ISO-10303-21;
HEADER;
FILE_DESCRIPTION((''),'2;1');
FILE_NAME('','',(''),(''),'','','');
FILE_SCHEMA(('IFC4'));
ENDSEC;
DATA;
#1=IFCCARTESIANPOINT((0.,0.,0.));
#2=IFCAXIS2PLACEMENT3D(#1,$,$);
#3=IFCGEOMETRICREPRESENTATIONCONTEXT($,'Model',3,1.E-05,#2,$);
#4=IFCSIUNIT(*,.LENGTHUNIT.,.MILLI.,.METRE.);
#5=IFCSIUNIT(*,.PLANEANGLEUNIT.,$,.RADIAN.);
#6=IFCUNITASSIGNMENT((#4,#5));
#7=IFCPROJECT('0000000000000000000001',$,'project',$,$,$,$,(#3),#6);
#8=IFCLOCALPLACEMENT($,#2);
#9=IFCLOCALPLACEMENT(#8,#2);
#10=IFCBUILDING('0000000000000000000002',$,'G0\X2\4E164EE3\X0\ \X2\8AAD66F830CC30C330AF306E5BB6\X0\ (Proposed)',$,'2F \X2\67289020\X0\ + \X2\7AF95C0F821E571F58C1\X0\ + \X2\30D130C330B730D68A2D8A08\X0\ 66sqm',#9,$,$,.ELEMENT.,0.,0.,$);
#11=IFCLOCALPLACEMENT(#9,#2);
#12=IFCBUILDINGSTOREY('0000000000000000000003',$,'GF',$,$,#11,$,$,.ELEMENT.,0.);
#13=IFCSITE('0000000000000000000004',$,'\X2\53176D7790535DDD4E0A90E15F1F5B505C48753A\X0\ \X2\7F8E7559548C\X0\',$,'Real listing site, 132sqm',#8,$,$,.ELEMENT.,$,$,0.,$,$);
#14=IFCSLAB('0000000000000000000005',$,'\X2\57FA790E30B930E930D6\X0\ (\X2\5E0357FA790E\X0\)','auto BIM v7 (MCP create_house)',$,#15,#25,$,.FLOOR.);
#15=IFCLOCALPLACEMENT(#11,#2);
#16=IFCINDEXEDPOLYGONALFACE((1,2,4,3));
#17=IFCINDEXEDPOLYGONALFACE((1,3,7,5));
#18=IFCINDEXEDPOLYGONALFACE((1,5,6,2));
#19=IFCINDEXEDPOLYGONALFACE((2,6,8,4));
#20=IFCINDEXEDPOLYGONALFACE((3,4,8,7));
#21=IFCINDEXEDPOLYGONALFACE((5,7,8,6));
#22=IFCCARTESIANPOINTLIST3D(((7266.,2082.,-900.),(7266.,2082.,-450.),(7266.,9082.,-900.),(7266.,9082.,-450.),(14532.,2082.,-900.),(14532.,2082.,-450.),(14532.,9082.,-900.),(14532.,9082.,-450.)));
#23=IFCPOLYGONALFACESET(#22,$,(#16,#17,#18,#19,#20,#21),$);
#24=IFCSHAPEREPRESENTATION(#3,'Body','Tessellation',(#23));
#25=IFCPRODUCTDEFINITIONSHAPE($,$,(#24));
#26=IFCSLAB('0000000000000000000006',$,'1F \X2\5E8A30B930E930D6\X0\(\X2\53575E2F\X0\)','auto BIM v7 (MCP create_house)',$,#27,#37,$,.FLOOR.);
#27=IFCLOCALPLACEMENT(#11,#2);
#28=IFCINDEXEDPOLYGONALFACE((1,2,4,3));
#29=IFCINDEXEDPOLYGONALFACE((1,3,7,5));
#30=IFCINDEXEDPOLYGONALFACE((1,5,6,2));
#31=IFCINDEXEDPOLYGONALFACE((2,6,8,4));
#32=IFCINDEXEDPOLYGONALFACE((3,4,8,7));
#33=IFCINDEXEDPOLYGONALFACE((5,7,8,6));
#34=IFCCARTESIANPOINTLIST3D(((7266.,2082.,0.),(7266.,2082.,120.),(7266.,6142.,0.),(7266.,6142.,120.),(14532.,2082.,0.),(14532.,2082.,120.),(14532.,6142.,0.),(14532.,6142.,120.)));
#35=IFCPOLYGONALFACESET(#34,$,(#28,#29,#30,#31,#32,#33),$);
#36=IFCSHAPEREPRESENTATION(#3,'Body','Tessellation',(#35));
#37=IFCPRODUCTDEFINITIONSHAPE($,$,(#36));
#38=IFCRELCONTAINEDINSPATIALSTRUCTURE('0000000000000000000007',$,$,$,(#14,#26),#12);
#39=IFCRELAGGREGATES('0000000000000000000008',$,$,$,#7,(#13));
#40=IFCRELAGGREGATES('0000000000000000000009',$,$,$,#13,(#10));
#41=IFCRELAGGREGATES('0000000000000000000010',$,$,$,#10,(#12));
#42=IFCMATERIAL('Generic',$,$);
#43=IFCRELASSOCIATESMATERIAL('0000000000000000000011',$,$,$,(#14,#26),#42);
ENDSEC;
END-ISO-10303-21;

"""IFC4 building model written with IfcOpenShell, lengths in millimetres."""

from ifc_helpers import new_model, si_unit, frame, frame_2d, origin, place, context, project, spatial, rectangle, extrude, material, element, save


model = new_model("IFC4")

# Units and contexts
model_context = context("Model", 3, precision=1e-05, world=origin())
ifc_project = project(units=[si_unit("LENGTHUNIT", "METRE", prefix="MILLI"), si_unit("PLANEANGLEUNIT", "RADIAN")], contexts=[model_context])

# Site, building, storey
site_placement = place(None, origin())
site = spatial("IfcSite", under=ifc_project, at=site_placement, Name="北海道川上郡弟子屈町 美留和", ObjectType="Real listing site, 132sqm", CompositionType="ELEMENT", RefElevation=0.0)
building_placement = place(site_placement, origin())
building = spatial("IfcBuilding", under=site, at=building_placement, Name="G0世代 読書ヌックの家 (Proposed)", ObjectType="2F 木造 + 竹小舞土壁 + パッシブ設計 66sqm", CompositionType="ELEMENT", ElevationOfRefHeight=0.0, ElevationOfTerrain=0.0)
storey_placement = place(building_placement, origin())
storey = spatial("IfcBuildingStorey", under=building, at=storey_placement, Name="GF", CompositionType="ELEMENT", Elevation=0.0)

# Slabs
ifc_material = material(Name="Generic")
slab_1_placement = place(storey_placement, frame((3633.0, 1041.0, -450.0)))
element("IfcSlab", 1, at=slab_1_placement, inside=storey, material=ifc_material, Name="基礎スラブ (布基礎)", Description="auto BIM v7 (MCP create_house)", PredefinedType="FLOOR", context=model_context, shape_type="SweptSolid", body=[
    extrude(rectangle(XDim=7266.0, YDim=7000.0, at=frame_2d((3633.0, 3500.0))), frame((3633.0, 1041.0, -450.0)), (0.0, 0.0, 1.0), 450.0),
])
slab_2_placement = place(storey_placement, frame((3633.0, 1041.0, 0.0)))
element("IfcSlab", 2, at=slab_2_placement, inside=storey, material=ifc_material, Name="1F 床スラブ(南帯)", Description="auto BIM v7 (MCP create_house)", PredefinedType="FLOOR", context=model_context, shape_type="SweptSolid", body=[
    extrude(rectangle(XDim=7266.0, YDim=4060.0, at=frame_2d((3633.0, 2030.0))), frame((3633.0, 1041.0, 0.0)), (0.0, 0.0, 1.0), 120.0),
])

save(model, "model.ifc")
